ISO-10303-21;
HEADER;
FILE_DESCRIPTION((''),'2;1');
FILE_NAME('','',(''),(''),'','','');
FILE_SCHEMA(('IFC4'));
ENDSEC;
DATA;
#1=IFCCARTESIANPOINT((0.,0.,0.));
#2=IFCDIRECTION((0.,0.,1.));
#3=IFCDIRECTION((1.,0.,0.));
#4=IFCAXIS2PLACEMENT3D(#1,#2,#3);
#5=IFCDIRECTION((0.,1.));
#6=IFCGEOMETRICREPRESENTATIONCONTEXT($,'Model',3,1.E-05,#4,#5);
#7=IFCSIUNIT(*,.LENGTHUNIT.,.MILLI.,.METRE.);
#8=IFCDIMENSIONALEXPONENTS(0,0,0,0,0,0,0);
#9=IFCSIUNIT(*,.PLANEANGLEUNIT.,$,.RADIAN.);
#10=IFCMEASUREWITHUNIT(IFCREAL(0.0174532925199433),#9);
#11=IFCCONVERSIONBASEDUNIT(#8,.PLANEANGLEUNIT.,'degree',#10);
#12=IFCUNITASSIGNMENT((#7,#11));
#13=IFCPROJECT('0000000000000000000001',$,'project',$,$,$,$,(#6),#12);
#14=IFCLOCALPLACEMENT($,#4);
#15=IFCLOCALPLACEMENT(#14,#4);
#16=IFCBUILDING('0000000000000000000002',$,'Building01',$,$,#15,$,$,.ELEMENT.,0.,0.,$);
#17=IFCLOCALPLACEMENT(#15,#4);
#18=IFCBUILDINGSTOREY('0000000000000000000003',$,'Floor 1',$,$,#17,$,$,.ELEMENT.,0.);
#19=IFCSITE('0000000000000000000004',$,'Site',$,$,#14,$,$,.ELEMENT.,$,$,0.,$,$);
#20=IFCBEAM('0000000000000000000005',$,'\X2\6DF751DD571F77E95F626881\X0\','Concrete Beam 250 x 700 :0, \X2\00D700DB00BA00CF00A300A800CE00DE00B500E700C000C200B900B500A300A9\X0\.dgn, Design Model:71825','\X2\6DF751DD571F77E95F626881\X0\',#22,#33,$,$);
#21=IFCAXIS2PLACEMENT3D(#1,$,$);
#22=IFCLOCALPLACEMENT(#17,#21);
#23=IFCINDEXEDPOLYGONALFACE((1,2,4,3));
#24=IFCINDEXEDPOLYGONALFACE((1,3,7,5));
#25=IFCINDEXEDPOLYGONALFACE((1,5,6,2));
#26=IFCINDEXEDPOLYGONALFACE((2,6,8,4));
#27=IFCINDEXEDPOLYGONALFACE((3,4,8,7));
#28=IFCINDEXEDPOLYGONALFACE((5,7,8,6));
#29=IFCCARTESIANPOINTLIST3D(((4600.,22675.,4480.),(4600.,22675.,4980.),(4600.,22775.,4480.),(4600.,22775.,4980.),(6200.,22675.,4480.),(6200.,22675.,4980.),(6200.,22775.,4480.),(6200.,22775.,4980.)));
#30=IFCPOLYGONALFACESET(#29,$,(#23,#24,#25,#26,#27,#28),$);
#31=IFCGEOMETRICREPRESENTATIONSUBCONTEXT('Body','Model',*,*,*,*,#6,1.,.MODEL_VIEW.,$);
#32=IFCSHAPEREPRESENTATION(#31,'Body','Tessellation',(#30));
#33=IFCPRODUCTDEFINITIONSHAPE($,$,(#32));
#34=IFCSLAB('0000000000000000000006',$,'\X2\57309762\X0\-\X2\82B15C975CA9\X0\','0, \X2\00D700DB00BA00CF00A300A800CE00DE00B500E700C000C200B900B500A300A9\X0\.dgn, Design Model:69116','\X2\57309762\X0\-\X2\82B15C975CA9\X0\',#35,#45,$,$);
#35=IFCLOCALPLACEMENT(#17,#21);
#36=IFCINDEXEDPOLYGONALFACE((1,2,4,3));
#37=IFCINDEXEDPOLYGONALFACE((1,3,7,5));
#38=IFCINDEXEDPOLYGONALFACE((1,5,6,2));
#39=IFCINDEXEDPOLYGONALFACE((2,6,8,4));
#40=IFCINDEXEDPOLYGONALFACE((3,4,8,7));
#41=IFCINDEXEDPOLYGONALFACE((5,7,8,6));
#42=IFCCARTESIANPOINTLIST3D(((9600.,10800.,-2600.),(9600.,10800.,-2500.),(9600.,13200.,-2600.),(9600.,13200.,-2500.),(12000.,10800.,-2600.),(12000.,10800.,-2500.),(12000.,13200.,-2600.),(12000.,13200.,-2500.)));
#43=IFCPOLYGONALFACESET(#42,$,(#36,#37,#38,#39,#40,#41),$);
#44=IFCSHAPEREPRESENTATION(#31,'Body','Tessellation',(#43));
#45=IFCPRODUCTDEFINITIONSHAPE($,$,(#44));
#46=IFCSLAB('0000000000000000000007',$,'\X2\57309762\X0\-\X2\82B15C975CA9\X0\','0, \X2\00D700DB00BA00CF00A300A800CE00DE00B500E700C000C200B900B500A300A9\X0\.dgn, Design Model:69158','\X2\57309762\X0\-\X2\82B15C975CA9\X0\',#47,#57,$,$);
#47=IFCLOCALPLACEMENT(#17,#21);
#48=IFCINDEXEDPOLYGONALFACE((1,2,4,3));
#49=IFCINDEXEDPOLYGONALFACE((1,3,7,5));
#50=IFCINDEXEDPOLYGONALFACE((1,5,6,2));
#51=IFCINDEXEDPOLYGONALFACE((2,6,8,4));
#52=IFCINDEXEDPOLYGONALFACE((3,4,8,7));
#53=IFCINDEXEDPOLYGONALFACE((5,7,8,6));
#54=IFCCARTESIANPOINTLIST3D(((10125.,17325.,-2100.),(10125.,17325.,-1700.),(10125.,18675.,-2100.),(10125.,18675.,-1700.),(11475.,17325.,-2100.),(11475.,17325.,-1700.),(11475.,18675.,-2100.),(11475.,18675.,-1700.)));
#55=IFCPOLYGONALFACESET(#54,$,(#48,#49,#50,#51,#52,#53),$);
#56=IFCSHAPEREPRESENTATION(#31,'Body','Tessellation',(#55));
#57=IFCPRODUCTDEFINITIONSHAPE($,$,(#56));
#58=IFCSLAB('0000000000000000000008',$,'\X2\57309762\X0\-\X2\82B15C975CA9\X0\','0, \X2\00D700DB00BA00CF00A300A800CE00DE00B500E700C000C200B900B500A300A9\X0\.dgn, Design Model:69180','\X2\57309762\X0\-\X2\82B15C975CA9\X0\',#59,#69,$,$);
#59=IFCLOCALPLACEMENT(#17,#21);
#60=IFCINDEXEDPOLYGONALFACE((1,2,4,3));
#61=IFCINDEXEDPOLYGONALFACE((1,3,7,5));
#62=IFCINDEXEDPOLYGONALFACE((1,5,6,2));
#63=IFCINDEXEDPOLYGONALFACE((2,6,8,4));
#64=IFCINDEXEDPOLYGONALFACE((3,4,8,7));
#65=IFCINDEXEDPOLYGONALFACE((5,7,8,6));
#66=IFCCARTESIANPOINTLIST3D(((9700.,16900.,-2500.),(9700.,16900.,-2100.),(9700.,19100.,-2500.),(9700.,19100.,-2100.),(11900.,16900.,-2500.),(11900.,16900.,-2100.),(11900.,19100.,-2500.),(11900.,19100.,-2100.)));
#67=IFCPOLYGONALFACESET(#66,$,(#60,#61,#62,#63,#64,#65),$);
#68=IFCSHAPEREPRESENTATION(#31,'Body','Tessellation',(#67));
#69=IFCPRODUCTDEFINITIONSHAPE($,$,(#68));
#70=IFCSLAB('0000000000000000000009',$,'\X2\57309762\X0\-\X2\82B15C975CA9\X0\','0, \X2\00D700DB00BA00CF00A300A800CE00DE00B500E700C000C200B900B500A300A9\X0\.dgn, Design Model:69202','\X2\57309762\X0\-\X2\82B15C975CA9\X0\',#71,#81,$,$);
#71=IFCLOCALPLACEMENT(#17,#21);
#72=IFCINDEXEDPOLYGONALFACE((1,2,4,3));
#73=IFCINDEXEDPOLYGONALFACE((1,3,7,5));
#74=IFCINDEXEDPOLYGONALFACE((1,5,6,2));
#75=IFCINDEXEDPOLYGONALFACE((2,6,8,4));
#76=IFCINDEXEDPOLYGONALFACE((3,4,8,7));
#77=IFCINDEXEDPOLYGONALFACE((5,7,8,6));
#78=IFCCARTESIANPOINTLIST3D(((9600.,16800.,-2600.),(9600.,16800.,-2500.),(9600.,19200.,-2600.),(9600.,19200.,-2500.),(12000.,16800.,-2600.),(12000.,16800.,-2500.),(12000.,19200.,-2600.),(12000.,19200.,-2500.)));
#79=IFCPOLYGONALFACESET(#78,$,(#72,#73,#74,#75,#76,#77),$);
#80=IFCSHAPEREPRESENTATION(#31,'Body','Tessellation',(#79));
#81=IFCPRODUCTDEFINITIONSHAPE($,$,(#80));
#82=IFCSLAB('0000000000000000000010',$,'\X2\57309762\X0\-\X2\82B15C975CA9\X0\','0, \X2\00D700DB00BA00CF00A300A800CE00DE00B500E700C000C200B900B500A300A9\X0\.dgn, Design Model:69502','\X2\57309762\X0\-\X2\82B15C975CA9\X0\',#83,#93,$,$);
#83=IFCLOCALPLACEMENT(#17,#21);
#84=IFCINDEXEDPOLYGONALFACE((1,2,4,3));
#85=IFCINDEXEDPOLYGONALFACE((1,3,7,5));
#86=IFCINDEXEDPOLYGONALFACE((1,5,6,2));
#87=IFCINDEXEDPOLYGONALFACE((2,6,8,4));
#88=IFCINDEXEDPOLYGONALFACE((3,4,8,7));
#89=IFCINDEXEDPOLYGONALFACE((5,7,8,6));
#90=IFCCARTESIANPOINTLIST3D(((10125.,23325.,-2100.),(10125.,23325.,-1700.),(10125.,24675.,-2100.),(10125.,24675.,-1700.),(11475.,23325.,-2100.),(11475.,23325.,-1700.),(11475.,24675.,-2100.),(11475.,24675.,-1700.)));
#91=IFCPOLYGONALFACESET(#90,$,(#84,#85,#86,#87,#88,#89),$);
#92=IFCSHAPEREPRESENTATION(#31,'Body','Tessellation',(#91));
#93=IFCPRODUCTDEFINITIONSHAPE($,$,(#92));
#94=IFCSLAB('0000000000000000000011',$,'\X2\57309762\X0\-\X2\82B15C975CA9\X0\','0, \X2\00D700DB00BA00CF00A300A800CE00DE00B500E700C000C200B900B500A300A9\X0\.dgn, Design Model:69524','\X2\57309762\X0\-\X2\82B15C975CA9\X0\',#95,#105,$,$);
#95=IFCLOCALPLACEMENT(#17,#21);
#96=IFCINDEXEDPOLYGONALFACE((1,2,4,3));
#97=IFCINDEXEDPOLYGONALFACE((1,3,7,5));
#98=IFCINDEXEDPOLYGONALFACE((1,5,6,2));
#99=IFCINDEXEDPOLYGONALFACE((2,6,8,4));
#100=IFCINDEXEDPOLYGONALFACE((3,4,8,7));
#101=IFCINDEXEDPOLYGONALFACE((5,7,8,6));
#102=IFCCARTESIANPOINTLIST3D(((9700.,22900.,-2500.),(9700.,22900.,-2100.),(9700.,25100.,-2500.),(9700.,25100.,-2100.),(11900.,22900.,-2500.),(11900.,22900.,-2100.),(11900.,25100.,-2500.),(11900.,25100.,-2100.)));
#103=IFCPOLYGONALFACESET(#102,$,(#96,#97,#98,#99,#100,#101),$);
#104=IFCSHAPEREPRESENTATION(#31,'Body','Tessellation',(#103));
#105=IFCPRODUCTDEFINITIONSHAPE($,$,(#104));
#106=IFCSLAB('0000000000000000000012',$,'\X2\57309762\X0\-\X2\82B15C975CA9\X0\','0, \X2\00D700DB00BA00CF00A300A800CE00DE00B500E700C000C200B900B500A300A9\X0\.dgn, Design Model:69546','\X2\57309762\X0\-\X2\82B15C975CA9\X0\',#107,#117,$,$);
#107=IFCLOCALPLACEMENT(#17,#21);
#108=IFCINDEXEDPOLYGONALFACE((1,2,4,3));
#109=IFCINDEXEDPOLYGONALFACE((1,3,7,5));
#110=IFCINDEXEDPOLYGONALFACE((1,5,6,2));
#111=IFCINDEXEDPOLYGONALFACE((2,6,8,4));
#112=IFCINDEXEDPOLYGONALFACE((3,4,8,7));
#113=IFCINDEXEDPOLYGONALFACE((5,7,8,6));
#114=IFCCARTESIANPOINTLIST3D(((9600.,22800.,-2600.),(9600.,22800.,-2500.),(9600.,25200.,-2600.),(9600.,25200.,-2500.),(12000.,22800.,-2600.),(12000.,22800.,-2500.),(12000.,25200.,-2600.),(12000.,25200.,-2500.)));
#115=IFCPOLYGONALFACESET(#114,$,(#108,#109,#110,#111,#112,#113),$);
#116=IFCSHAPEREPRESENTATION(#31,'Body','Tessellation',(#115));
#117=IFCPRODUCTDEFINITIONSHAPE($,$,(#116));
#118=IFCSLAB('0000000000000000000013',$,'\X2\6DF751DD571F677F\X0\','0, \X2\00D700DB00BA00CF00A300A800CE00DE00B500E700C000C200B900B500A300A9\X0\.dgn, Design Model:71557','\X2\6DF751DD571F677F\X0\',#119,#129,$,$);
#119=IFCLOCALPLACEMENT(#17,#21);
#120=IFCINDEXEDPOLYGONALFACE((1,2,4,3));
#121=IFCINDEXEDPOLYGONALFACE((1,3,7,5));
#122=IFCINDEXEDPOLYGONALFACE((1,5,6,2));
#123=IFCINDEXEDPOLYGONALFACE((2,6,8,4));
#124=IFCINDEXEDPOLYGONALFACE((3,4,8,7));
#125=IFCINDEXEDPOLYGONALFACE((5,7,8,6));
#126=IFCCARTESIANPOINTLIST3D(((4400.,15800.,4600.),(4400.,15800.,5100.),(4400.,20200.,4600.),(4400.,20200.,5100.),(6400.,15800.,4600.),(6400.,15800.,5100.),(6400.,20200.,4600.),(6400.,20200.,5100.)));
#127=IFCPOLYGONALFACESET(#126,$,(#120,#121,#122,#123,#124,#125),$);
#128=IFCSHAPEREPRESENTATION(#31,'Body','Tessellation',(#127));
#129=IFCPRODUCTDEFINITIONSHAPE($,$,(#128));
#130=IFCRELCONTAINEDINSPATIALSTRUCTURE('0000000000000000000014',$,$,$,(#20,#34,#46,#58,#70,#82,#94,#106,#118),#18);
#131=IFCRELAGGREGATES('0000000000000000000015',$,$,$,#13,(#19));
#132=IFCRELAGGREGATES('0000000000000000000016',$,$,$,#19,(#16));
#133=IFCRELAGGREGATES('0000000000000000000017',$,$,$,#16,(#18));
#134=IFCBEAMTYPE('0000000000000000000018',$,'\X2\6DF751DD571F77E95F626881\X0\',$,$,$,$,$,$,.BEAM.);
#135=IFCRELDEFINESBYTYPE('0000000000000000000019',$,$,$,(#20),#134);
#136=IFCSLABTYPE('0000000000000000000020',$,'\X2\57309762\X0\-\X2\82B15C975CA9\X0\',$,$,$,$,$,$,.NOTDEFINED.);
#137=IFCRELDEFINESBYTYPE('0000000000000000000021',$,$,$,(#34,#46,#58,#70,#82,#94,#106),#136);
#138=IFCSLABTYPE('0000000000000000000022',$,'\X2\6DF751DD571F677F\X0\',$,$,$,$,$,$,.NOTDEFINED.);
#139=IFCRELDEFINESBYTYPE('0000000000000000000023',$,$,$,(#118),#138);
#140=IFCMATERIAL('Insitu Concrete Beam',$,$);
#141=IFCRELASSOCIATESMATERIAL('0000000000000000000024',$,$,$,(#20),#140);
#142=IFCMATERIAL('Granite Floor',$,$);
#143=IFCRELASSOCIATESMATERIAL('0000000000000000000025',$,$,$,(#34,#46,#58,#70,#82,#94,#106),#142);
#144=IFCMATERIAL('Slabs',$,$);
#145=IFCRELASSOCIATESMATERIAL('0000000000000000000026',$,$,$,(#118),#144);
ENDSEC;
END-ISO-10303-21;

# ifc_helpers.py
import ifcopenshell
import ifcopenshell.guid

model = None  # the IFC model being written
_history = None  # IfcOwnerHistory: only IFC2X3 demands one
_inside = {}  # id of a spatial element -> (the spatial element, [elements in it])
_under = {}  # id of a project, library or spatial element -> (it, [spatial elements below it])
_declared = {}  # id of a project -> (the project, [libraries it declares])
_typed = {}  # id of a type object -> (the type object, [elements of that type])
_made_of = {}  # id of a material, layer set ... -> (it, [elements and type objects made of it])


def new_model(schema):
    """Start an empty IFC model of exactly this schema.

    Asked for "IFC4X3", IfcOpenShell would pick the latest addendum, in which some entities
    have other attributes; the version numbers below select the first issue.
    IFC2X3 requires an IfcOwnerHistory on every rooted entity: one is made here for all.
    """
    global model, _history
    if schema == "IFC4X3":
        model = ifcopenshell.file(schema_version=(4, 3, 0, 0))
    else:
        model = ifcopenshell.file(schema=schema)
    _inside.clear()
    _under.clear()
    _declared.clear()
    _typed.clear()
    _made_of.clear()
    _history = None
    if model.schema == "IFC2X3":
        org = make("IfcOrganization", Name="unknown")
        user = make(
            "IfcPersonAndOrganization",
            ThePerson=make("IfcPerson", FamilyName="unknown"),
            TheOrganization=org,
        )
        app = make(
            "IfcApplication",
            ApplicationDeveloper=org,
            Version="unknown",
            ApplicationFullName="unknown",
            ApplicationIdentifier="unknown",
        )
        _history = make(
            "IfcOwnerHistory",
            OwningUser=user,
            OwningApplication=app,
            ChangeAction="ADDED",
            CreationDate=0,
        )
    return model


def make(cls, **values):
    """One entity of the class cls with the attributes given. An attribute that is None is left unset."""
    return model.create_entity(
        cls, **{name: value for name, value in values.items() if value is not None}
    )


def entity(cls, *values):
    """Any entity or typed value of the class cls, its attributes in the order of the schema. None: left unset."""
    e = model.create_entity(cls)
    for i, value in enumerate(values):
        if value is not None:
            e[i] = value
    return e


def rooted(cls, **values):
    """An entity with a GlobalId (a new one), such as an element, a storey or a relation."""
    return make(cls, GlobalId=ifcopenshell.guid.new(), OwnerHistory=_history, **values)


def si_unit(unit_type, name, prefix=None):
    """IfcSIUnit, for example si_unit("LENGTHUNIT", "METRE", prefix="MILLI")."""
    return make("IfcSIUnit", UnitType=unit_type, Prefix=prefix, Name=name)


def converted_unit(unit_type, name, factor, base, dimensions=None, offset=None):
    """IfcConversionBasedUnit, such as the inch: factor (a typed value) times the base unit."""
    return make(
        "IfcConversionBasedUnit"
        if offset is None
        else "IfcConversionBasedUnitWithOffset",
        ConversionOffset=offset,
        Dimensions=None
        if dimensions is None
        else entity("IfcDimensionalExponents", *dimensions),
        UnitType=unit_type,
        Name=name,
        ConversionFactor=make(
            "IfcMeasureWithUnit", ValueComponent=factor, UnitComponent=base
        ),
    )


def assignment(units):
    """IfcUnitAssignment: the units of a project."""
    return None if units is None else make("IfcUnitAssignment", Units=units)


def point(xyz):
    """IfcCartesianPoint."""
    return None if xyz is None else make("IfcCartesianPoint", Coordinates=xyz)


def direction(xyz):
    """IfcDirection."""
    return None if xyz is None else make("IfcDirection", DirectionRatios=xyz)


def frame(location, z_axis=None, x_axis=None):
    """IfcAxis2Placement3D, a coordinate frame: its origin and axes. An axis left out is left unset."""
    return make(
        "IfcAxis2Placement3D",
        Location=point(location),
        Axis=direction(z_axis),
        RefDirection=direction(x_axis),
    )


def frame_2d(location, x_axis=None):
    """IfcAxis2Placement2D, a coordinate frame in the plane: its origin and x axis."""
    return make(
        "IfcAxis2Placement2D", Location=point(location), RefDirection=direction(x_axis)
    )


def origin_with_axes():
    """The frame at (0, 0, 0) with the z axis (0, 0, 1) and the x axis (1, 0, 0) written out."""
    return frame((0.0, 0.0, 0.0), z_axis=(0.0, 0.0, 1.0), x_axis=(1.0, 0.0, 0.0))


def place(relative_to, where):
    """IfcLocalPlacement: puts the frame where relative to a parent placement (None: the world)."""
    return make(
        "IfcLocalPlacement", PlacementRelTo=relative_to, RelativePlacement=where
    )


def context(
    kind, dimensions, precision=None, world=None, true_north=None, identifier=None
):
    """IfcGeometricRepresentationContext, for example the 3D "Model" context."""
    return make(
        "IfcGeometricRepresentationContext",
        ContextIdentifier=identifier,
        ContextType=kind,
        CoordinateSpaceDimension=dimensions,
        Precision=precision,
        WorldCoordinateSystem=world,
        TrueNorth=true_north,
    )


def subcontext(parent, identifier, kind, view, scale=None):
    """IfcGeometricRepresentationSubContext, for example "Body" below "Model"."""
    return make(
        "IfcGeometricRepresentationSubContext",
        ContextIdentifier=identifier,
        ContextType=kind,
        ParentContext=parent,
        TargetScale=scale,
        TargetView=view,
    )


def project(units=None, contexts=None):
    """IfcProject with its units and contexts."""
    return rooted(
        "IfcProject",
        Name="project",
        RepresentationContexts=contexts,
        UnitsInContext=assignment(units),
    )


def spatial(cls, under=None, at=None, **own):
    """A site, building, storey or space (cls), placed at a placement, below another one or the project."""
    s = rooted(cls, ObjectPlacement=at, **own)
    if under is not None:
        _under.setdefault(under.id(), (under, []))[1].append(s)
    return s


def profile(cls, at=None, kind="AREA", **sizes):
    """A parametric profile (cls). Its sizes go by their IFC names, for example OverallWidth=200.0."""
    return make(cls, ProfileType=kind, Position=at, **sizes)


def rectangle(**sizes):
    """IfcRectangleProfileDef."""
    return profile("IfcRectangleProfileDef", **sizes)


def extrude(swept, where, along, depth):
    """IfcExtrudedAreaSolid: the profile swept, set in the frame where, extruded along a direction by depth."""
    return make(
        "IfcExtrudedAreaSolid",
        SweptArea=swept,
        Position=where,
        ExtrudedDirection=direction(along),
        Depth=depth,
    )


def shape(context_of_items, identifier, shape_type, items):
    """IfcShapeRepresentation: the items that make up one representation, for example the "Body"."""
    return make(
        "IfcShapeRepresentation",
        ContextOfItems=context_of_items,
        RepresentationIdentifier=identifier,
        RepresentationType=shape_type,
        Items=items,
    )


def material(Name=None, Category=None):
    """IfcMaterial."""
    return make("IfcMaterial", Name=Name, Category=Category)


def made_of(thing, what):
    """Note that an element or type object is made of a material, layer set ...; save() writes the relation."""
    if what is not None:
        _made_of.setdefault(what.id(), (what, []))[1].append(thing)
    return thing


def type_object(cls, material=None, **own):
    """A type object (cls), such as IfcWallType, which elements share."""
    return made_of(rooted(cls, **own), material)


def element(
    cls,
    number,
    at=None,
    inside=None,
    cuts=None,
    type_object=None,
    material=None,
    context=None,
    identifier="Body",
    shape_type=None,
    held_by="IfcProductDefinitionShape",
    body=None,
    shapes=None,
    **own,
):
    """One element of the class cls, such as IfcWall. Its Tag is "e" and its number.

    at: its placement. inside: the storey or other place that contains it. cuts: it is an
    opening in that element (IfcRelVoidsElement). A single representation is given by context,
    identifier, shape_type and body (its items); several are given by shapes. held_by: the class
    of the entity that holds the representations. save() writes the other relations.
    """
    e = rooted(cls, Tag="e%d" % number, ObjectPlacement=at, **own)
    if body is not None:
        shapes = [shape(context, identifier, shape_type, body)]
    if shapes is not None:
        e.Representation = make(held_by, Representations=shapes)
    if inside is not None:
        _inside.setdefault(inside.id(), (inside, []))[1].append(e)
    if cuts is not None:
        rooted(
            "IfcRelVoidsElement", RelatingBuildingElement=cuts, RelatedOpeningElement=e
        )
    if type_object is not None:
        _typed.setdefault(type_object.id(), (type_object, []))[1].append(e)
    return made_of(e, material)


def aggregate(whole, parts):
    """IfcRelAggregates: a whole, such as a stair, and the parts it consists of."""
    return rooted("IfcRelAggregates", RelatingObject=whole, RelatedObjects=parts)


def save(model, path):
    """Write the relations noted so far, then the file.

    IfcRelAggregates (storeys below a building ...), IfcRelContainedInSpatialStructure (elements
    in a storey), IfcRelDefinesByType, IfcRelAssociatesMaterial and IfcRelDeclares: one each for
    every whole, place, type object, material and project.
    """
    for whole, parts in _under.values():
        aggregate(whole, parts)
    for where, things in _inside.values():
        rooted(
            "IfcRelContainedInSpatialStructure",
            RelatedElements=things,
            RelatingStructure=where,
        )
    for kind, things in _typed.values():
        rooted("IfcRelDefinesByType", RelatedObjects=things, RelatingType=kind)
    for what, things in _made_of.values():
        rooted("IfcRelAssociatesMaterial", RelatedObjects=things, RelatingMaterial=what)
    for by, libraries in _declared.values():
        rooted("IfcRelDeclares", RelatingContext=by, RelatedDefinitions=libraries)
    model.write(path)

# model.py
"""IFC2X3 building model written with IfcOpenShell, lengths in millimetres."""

from ifc_helpers import new_model, entity, si_unit, converted_unit, direction, frame, frame_2d, origin_with_axes, place, context, subcontext, project, spatial, rectangle, extrude, material, type_object, element, save


model = new_model("IFC2X3")

# Units and contexts
model_context = context("Model", 3, precision=1e-05, world=origin_with_axes(), true_north=direction((0.0, 1.0)))
body_context = subcontext(model_context, "Body", "Model", "MODEL_VIEW", scale=1.0)
ifc_project = project(units=[si_unit("LENGTHUNIT", "METRE", prefix="MILLI"), converted_unit("PLANEANGLEUNIT", "degree", entity("IfcReal", 0.0174532925199433), si_unit("PLANEANGLEUNIT", "RADIAN"), dimensions=[0, 0, 0, 0, 0, 0, 0])], contexts=[model_context])

# Site, building, storey
site_placement = place(None, origin_with_axes())
site = spatial("IfcSite", under=ifc_project, at=site_placement, Name="Site", CompositionType="ELEMENT", RefElevation=0.0)
building_placement = place(site_placement, origin_with_axes())
building = spatial("IfcBuilding", under=site, at=building_placement, Name="Building01", CompositionType="ELEMENT", ElevationOfRefHeight=0.0, ElevationOfTerrain=0.0)
storey_placement = place(building_placement, origin_with_axes())
storey = spatial("IfcBuildingStorey", under=building, at=storey_placement, Name="Floor 1", CompositionType="ELEMENT", Elevation=0.0)

# Beam
ifc_material_1 = material(Name="Insitu Concrete Beam")
beam_type = type_object("IfcBeamType", Name="混凝土矩形梁", PredefinedType="BEAM")
beam_1_placement = place(storey_placement, frame((6200.0, 22775.0, 4480.0), z_axis=(-1.0, 0.0, 0.0), x_axis=(0.0, -1.0, 0.0)))
element("IfcBeam", 1, at=beam_1_placement, inside=storey, type_object=beam_type, material=ifc_material_1, Name="混凝土矩形梁", Description="Concrete Beam 250 x 700 :0, ×ÛºÏ£¨ÎÞµçÀÂ¹µ£©.dgn, Design Model:71825", ObjectType="混凝土矩形梁", context=body_context, shape_type="SweptSolid", body=[
    extrude(rectangle(XDim=500.0, YDim=100.0, at=frame_2d((50.0, 250.0), x_axis=(0.0, 1.0))), origin_with_axes(), (0.0, 0.0, 1.0), 1600.0),
])

# Slabs
ifc_material_2 = material(Name="Granite Floor")
slab_type_1 = type_object("IfcSlabType", Name="地面-花岗岩", PredefinedType="NOTDEFINED")
slab_1_placement = place(storey_placement, frame((12000.0, 13200.0, -2500.0), z_axis=(0.0, 0.0, -1.0), x_axis=(0.0, -1.0, 0.0)))
element("IfcSlab", 2, at=slab_1_placement, inside=storey, type_object=slab_type_1, material=ifc_material_2, Name="地面-花岗岩", Description="0, ×ÛºÏ£¨ÎÞµçÀÂ¹µ£©.dgn, Design Model:69116", ObjectType="地面-花岗岩", context=body_context, shape_type="SweptSolid", body=[
    extrude(rectangle(XDim=2400.0, YDim=2400.0, at=frame_2d((1200.0, 1200.0), x_axis=(1.0, 0.0))), origin_with_axes(), (0.0, 0.0, 1.0), 100.0),
])
slab_2_placement = place(storey_placement, frame((10125.0, 17325.0, -2100.0), z_axis=(0.0, 0.0, 1.0), x_axis=(1.0, 0.0, 0.0)))
element("IfcSlab", 3, at=slab_2_placement, inside=storey, type_object=slab_type_1, material=ifc_material_2, Name="地面-花岗岩", Description="0, ×ÛºÏ£¨ÎÞµçÀÂ¹µ£©.dgn, Design Model:69158", ObjectType="地面-花岗岩", context=body_context, shape_type="SweptSolid", body=[
    extrude(rectangle(XDim=1350.0, YDim=1350.0, at=frame_2d((675.0, 675.0), x_axis=(1.0, 0.0))), origin_with_axes(), (0.0, 0.0, 1.0), 400.0),
])
slab_3_placement = place(storey_placement, frame((9700.0, 16900.0, -2500.0), z_axis=(0.0, 0.0, 1.0), x_axis=(1.0, 0.0, 0.0)))
element("IfcSlab", 4, at=slab_3_placement, inside=storey, type_object=slab_type_1, material=ifc_material_2, Name="地面-花岗岩", Description="0, ×ÛºÏ£¨ÎÞµçÀÂ¹µ£©.dgn, Design Model:69180", ObjectType="地面-花岗岩", context=body_context, shape_type="SweptSolid", body=[
    extrude(rectangle(XDim=2200.0, YDim=2200.0, at=frame_2d((1100.0, 1100.0), x_axis=(1.0, 0.0))), origin_with_axes(), (0.0, 0.0, 1.0), 400.0),
])
slab_4_placement = place(storey_placement, frame((12000.0, 19200.0, -2500.0), z_axis=(0.0, 0.0, -1.0), x_axis=(0.0, -1.0, 0.0)))
element("IfcSlab", 5, at=slab_4_placement, inside=storey, type_object=slab_type_1, material=ifc_material_2, Name="地面-花岗岩", Description="0, ×ÛºÏ£¨ÎÞµçÀÂ¹µ£©.dgn, Design Model:69202", ObjectType="地面-花岗岩", context=body_context, shape_type="SweptSolid", body=[
    extrude(rectangle(XDim=2400.0, YDim=2400.0, at=frame_2d((1200.0, 1200.0), x_axis=(1.0, 0.0))), origin_with_axes(), (0.0, 0.0, 1.0), 100.0),
])
slab_5_placement = place(storey_placement, frame((10125.0, 23325.0, -2100.0), z_axis=(0.0, 0.0, 1.0), x_axis=(1.0, 0.0, 0.0)))
element("IfcSlab", 6, at=slab_5_placement, inside=storey, type_object=slab_type_1, material=ifc_material_2, Name="地面-花岗岩", Description="0, ×ÛºÏ£¨ÎÞµçÀÂ¹µ£©.dgn, Design Model:69502", ObjectType="地面-花岗岩", context=body_context, shape_type="SweptSolid", body=[
    extrude(rectangle(XDim=1350.0, YDim=1350.0, at=frame_2d((675.0, 675.0), x_axis=(1.0, 0.0))), origin_with_axes(), (0.0, 0.0, 1.0), 400.0),
])
slab_6_placement = place(storey_placement, frame((9700.0, 22900.0, -2500.0), z_axis=(0.0, 0.0, 1.0), x_axis=(1.0, 0.0, 0.0)))
element("IfcSlab", 7, at=slab_6_placement, inside=storey, type_object=slab_type_1, material=ifc_material_2, Name="地面-花岗岩", Description="0, ×ÛºÏ£¨ÎÞµçÀÂ¹µ£©.dgn, Design Model:69524", ObjectType="地面-花岗岩", context=body_context, shape_type="SweptSolid", body=[
    extrude(rectangle(XDim=2200.0, YDim=2200.0, at=frame_2d((1100.0, 1100.0), x_axis=(1.0, 0.0))), origin_with_axes(), (0.0, 0.0, 1.0), 400.0),
])
slab_7_placement = place(storey_placement, frame((12000.0, 25200.0, -2500.0), z_axis=(0.0, 0.0, -1.0), x_axis=(0.0, -1.0, 0.0)))
element("IfcSlab", 8, at=slab_7_placement, inside=storey, type_object=slab_type_1, material=ifc_material_2, Name="地面-花岗岩", Description="0, ×ÛºÏ£¨ÎÞµçÀÂ¹µ£©.dgn, Design Model:69546", ObjectType="地面-花岗岩", context=body_context, shape_type="SweptSolid", body=[
    extrude(rectangle(XDim=2400.0, YDim=2400.0, at=frame_2d((1200.0, 1200.0), x_axis=(1.0, 0.0))), origin_with_axes(), (0.0, 0.0, 1.0), 100.0),
])
ifc_material_3 = material(Name="Slabs")
slab_type_2 = type_object("IfcSlabType", Name="混凝土板", PredefinedType="NOTDEFINED")
slab_8_placement = place(storey_placement, frame((6400.0, 20200.0, 4600.0), z_axis=(0.0, 0.0, 1.0), x_axis=(-1.0, 0.0, 0.0)))
element("IfcSlab", 9, at=slab_8_placement, inside=storey, type_object=slab_type_2, material=ifc_material_3, Name="混凝土板", Description="0, ×ÛºÏ£¨ÎÞµçÀÂ¹µ£©.dgn, Design Model:71557", ObjectType="混凝土板", context=body_context, shape_type="SweptSolid", body=[
    extrude(rectangle(XDim=2000.0, YDim=4400.0, at=frame_2d((1000.0, 2200.0), x_axis=(1.0, 0.0))), origin_with_axes(), (0.0, 0.0, 1.0), 500.0),
])

save(model, "model.ifc")
